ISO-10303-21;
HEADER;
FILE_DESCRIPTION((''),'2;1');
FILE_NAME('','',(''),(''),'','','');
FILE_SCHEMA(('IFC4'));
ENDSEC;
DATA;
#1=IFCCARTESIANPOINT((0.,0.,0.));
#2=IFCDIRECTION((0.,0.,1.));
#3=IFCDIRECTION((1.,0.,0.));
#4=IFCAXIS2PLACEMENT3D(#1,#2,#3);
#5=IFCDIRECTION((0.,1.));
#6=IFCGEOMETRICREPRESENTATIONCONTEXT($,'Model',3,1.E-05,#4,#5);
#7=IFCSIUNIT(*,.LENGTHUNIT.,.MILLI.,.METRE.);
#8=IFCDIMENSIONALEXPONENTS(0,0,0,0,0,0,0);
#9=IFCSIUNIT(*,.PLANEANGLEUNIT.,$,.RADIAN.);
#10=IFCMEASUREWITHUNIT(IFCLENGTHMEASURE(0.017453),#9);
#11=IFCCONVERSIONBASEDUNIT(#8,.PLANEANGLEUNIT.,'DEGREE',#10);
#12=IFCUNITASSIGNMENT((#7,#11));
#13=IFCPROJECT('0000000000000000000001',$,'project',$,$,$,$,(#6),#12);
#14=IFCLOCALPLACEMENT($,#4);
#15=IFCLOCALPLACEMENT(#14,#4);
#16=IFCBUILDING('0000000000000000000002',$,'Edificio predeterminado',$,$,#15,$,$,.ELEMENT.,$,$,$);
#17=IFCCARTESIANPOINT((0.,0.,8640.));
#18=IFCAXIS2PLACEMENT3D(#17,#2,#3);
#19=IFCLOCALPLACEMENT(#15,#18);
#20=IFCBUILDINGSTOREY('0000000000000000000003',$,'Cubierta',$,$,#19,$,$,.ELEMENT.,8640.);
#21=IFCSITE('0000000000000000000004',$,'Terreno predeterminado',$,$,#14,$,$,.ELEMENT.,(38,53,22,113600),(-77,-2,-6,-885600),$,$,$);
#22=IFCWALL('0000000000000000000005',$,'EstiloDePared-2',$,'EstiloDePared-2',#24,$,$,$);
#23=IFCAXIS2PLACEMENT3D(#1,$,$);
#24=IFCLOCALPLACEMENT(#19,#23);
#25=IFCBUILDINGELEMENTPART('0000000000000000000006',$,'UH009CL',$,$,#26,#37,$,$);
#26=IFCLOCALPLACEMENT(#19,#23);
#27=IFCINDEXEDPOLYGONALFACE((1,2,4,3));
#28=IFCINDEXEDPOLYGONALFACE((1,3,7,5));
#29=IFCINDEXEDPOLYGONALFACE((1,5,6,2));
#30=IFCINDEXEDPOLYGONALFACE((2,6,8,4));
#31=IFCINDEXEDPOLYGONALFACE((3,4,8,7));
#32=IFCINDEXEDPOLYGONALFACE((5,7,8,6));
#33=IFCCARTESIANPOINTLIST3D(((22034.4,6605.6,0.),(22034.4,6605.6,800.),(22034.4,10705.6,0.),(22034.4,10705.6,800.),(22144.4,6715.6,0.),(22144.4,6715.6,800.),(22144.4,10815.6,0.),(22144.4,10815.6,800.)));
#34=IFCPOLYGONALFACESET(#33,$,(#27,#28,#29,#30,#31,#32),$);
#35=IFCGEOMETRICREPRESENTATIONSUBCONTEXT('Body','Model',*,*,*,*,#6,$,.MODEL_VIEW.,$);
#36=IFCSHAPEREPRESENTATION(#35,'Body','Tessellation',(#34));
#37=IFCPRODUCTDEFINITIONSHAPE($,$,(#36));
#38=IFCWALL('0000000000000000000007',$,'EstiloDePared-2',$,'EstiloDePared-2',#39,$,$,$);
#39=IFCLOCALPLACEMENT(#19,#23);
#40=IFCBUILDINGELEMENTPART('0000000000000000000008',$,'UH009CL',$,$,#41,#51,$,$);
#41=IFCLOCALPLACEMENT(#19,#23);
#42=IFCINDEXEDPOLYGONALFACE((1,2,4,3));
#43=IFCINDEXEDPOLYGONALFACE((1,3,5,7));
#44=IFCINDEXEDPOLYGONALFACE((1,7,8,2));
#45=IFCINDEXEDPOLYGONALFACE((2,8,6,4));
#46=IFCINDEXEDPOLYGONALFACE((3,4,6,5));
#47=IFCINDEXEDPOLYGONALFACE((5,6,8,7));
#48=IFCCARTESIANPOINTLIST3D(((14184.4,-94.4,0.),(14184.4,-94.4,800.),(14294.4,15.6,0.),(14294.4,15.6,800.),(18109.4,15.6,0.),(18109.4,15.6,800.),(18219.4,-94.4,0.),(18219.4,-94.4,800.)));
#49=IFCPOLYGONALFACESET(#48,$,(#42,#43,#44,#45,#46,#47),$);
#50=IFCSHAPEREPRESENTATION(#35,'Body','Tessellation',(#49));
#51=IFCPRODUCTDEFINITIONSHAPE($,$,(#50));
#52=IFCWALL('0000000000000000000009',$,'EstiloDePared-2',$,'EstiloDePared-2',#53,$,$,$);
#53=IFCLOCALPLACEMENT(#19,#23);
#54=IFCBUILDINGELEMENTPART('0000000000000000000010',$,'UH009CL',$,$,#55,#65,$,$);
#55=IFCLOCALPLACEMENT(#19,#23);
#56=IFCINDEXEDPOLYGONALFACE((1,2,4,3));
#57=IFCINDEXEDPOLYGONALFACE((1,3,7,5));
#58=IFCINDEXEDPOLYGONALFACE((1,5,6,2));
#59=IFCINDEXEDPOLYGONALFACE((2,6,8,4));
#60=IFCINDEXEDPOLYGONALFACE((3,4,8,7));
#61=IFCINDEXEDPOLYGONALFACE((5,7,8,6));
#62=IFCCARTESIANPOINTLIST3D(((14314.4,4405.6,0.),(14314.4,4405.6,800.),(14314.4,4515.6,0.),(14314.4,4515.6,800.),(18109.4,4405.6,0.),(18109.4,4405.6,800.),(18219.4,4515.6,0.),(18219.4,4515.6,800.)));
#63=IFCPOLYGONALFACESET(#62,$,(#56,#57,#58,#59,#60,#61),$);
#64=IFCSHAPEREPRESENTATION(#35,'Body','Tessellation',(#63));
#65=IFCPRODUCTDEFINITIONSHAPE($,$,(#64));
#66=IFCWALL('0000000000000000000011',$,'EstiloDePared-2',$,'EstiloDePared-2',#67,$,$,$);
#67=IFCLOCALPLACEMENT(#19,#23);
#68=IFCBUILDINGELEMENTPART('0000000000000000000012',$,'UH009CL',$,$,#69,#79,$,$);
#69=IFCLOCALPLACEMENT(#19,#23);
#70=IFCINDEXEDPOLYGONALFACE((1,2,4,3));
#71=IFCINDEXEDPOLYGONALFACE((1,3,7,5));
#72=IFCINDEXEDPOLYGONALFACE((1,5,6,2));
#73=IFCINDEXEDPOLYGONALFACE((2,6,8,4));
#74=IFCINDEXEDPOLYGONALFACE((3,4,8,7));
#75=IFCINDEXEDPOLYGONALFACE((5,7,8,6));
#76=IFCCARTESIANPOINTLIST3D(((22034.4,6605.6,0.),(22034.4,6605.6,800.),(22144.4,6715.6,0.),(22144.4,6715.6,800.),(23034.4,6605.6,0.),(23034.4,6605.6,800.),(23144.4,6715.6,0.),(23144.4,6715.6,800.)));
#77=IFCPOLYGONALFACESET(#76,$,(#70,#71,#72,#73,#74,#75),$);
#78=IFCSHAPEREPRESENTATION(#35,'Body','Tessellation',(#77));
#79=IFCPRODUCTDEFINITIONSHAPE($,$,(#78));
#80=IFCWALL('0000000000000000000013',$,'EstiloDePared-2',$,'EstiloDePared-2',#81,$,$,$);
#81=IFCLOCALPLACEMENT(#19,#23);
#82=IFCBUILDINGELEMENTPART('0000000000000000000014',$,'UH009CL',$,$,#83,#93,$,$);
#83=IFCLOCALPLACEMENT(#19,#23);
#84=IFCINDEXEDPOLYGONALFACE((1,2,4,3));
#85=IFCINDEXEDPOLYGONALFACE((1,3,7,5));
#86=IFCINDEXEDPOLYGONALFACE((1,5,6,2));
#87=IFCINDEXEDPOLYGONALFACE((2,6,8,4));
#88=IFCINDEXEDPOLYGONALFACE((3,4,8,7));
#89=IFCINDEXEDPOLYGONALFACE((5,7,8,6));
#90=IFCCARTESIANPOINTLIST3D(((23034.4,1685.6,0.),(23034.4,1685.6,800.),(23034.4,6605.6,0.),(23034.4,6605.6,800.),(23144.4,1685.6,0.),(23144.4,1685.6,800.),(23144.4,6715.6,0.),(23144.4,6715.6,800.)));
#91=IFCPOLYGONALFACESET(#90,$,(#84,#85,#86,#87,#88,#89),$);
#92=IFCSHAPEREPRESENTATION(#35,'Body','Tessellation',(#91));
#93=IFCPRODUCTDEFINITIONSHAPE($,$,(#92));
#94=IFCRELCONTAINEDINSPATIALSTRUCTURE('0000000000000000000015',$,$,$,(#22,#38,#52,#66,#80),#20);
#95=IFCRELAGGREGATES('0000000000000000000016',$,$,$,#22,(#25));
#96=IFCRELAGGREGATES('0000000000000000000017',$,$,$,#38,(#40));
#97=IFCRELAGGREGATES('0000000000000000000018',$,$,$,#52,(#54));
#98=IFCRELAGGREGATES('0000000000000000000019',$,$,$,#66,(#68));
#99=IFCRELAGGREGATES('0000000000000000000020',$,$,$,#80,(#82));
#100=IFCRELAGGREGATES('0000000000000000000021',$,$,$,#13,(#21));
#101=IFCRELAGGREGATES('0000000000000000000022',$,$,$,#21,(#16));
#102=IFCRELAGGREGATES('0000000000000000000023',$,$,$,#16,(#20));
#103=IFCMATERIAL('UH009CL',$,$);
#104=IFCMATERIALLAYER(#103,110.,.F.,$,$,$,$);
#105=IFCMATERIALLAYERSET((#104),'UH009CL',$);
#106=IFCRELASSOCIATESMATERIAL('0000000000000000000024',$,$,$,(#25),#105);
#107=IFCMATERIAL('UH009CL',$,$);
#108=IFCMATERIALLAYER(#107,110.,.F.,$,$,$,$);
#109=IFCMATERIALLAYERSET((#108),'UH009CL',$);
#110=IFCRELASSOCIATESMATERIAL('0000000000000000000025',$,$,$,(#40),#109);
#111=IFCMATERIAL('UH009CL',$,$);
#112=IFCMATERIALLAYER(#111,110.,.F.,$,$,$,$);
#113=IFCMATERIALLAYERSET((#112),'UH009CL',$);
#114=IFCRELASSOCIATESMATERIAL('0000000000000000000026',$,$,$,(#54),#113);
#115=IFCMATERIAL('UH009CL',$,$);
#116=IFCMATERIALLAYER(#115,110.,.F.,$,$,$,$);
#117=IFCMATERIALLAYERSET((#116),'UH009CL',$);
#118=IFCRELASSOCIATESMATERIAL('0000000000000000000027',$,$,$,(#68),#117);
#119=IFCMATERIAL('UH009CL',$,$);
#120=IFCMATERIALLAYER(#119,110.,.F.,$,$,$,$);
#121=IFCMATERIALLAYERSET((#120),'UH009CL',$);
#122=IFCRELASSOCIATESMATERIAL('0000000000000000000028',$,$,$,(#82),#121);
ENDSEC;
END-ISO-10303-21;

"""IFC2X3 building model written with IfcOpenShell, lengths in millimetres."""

from ifc_helpers import new_model, entity, si_unit, converted_unit, direction, frame, origin_with_axes, place, context, subcontext, project, spatial, polyline, outline, extrude, material, layer, layer_set, layer_usage, element, aggregate, save


model = new_model("IFC2X3")

# Units and contexts
model_context = context("Model", 3, precision=1e-05, world=origin_with_axes(), true_north=direction((0.0, 1.0)))
body_context = subcontext(model_context, "Body", "Model", "MODEL_VIEW")
ifc_project = project(units=[si_unit("LENGTHUNIT", "METRE", prefix="MILLI"), converted_unit("PLANEANGLEUNIT", "DEGREE", entity("IfcLengthMeasure", 0.017453), si_unit("PLANEANGLEUNIT", "RADIAN"), dimensions=[0, 0, 0, 0, 0, 0, 0])], contexts=[model_context])

# Site, building, storey
site_placement = place(None, origin_with_axes())
site = spatial("IfcSite", under=ifc_project, at=site_placement, Name="Terreno predeterminado", CompositionType="ELEMENT", RefLatitude=(38, 53, 22, 113600), RefLongitude=(-77, -2, -6, -885600))
building_placement = place(site_placement, origin_with_axes())
building = spatial("IfcBuilding", under=site, at=building_placement, Name="Edificio predeterminado", CompositionType="ELEMENT")
storey_placement = place(building_placement, frame((0.0, 0.0, 8640.0), z_axis=(0.0, 0.0, 1.0), x_axis=(1.0, 0.0, 0.0)))
storey = spatial("IfcBuildingStorey", under=building, at=storey_placement, Name="Cubierta", CompositionType="ELEMENT", Elevation=8640.0)

# Wall, building element part
wall_1_placement = place(storey_placement, frame((22089.4, 10760.6, 0.0), z_axis=(0.0, 0.0, 1.0), x_axis=(0.0, -1.0, 0.0)))
wall_1 = element("IfcWall", 1, at=wall_1_placement, inside=storey, Name="EstiloDePared-2", ObjectType="EstiloDePared-2")
ifc_material_1 = material(Name="UH009CL")
ifc_layer_1 = layer(ifc_material_1, 110.0, ventilated=False)
ifc_layer_set_1 = layer_set([ifc_layer_1], Name="UH009CL")
ifc_layer_usage_1 = layer_usage(ifc_layer_set_1, "AXIS2", "NEGATIVE", -55.0)
building_element_part_1_placement = place(wall_1_placement, origin_with_axes())
building_element_part_1 = element("IfcBuildingElementPart", 2, at=building_element_part_1_placement, material=ifc_layer_usage_1, Name="UH009CL", context=body_context, shape_type="SweptSolid", body=[
    extrude(outline(polyline([(4045.0, 55.0), (4155.0, -55.0), (55.0, -55.0), (-55.0, 55.0), (4045.0, 55.0)])), origin_with_axes(), (0.0, 0.0, 1.0), 800.0),
])
aggregate(wall_1, [building_element_part_1])

# Walls, building element parts
wall_2_placement = place(storey_placement, frame((18164.4, -39.4, 0.0), z_axis=(0.0, 0.0, 1.0), x_axis=(-1.0, 0.0, 0.0)))
wall_2 = element("IfcWall", 3, at=wall_2_placement, inside=storey, Name="EstiloDePared-2", ObjectType="EstiloDePared-2")
ifc_material_2 = material(Name="UH009CL")
ifc_layer_2 = layer(ifc_material_2, 110.0, ventilated=False)
ifc_layer_set_2 = layer_set([ifc_layer_2], Name="UH009CL")
ifc_layer_usage_2 = layer_usage(ifc_layer_set_2, "AXIS2", "NEGATIVE", -55.0)
building_element_part_2_placement = place(wall_2_placement, origin_with_axes())
building_element_part_2 = element("IfcBuildingElementPart", 4, at=building_element_part_2_placement, material=ifc_layer_usage_2, Name="UH009CL", context=body_context, shape_type="SweptSolid", body=[
    extrude(outline(polyline([(3980.0, 55.0), (3870.0, -55.0), (55.0, -55.0), (-55.0, 55.0), (3980.0, 55.0)])), origin_with_axes(), (0.0, 0.0, 1.0), 800.0),
])
aggregate(wall_2, [building_element_part_2])
wall_3_placement = place(storey_placement, frame((18164.4, 4460.6, 0.0), z_axis=(0.0, 0.0, 1.0), x_axis=(-1.0, 0.0, 0.0)))
wall_3 = element("IfcWall", 5, at=wall_3_placement, inside=storey, Name="EstiloDePared-2", ObjectType="EstiloDePared-2")
ifc_material_3 = material(Name="UH009CL")
ifc_layer_3 = layer(ifc_material_3, 110.0, ventilated=False)
ifc_layer_set_3 = layer_set([ifc_layer_3], Name="UH009CL")
ifc_layer_usage_3 = layer_usage(ifc_layer_set_3, "AXIS2", "NEGATIVE", -55.0)
building_element_part_3_placement = place(wall_3_placement, origin_with_axes())
building_element_part_3 = element("IfcBuildingElementPart", 6, at=building_element_part_3_placement, material=ifc_layer_usage_3, Name="UH009CL", context=body_context, shape_type="SweptSolid", body=[
    extrude(outline(polyline([(3850.0, 55.0), (3850.0, -55.0), (-55.0, -55.0), (55.0, 55.0), (3850.0, 55.0)])), origin_with_axes(), (0.0, 0.0, 1.0), 800.0),
])
aggregate(wall_3, [building_element_part_3])
wall_4_placement = place(storey_placement, frame((22089.4, 6660.6, 0.0), z_axis=(0.0, 0.0, 1.0), x_axis=(1.0, 0.0, 0.0)))
wall_4 = element("IfcWall", 7, at=wall_4_placement, inside=storey, Name="EstiloDePared-2", ObjectType="EstiloDePared-2")
ifc_material_4 = material(Name="UH009CL")
ifc_layer_4 = layer(ifc_material_4, 110.0, ventilated=False)
ifc_layer_set_4 = layer_set([ifc_layer_4], Name="UH009CL")
ifc_layer_usage_4 = layer_usage(ifc_layer_set_4, "AXIS2", "NEGATIVE", -55.0)
building_element_part_4_placement = place(wall_4_placement, origin_with_axes())
building_element_part_4 = element("IfcBuildingElementPart", 8, at=building_element_part_4_placement, material=ifc_layer_usage_4, Name="UH009CL", context=body_context, shape_type="SweptSolid", body=[
    extrude(outline(polyline([(1055.0, 55.0), (945.0, -55.0), (-55.0, -55.0), (55.0, 55.0), (1055.0, 55.0)])), origin_with_axes(), (0.0, 0.0, 1.0), 800.0),
])
aggregate(wall_4, [building_element_part_4])
wall_5_placement = place(storey_placement, frame((23089.4, 6660.6, 0.0), z_axis=(0.0, 0.0, 1.0), x_axis=(0.0, -1.0, 0.0)))
wall_5 = element("IfcWall", 9, at=wall_5_placement, inside=storey, Name="EstiloDePared-2", ObjectType="EstiloDePared-2")
ifc_material_5 = material(Name="UH009CL")
ifc_layer_5 = layer(ifc_material_5, 110.0, ventilated=False)
ifc_layer_set_5 = layer_set([ifc_layer_5], Name="UH009CL")
ifc_layer_usage_5 = layer_usage(ifc_layer_set_5, "AXIS2", "NEGATIVE", -55.0)
building_element_part_5_placement = place(wall_5_placement, origin_with_axes())
building_element_part_5 = element("IfcBuildingElementPart", 10, at=building_element_part_5_placement, material=ifc_layer_usage_5, Name="UH009CL", context=body_context, shape_type="SweptSolid", body=[
    extrude(outline(polyline([(4975.0, 55.0), (4975.0, -55.0), (55.0, -55.0), (-55.0, 55.0), (4975.0, 55.0)])), origin_with_axes(), (0.0, 0.0, 1.0), 800.0),
])
aggregate(wall_5, [building_element_part_5])

save(model, "model.ifc")
